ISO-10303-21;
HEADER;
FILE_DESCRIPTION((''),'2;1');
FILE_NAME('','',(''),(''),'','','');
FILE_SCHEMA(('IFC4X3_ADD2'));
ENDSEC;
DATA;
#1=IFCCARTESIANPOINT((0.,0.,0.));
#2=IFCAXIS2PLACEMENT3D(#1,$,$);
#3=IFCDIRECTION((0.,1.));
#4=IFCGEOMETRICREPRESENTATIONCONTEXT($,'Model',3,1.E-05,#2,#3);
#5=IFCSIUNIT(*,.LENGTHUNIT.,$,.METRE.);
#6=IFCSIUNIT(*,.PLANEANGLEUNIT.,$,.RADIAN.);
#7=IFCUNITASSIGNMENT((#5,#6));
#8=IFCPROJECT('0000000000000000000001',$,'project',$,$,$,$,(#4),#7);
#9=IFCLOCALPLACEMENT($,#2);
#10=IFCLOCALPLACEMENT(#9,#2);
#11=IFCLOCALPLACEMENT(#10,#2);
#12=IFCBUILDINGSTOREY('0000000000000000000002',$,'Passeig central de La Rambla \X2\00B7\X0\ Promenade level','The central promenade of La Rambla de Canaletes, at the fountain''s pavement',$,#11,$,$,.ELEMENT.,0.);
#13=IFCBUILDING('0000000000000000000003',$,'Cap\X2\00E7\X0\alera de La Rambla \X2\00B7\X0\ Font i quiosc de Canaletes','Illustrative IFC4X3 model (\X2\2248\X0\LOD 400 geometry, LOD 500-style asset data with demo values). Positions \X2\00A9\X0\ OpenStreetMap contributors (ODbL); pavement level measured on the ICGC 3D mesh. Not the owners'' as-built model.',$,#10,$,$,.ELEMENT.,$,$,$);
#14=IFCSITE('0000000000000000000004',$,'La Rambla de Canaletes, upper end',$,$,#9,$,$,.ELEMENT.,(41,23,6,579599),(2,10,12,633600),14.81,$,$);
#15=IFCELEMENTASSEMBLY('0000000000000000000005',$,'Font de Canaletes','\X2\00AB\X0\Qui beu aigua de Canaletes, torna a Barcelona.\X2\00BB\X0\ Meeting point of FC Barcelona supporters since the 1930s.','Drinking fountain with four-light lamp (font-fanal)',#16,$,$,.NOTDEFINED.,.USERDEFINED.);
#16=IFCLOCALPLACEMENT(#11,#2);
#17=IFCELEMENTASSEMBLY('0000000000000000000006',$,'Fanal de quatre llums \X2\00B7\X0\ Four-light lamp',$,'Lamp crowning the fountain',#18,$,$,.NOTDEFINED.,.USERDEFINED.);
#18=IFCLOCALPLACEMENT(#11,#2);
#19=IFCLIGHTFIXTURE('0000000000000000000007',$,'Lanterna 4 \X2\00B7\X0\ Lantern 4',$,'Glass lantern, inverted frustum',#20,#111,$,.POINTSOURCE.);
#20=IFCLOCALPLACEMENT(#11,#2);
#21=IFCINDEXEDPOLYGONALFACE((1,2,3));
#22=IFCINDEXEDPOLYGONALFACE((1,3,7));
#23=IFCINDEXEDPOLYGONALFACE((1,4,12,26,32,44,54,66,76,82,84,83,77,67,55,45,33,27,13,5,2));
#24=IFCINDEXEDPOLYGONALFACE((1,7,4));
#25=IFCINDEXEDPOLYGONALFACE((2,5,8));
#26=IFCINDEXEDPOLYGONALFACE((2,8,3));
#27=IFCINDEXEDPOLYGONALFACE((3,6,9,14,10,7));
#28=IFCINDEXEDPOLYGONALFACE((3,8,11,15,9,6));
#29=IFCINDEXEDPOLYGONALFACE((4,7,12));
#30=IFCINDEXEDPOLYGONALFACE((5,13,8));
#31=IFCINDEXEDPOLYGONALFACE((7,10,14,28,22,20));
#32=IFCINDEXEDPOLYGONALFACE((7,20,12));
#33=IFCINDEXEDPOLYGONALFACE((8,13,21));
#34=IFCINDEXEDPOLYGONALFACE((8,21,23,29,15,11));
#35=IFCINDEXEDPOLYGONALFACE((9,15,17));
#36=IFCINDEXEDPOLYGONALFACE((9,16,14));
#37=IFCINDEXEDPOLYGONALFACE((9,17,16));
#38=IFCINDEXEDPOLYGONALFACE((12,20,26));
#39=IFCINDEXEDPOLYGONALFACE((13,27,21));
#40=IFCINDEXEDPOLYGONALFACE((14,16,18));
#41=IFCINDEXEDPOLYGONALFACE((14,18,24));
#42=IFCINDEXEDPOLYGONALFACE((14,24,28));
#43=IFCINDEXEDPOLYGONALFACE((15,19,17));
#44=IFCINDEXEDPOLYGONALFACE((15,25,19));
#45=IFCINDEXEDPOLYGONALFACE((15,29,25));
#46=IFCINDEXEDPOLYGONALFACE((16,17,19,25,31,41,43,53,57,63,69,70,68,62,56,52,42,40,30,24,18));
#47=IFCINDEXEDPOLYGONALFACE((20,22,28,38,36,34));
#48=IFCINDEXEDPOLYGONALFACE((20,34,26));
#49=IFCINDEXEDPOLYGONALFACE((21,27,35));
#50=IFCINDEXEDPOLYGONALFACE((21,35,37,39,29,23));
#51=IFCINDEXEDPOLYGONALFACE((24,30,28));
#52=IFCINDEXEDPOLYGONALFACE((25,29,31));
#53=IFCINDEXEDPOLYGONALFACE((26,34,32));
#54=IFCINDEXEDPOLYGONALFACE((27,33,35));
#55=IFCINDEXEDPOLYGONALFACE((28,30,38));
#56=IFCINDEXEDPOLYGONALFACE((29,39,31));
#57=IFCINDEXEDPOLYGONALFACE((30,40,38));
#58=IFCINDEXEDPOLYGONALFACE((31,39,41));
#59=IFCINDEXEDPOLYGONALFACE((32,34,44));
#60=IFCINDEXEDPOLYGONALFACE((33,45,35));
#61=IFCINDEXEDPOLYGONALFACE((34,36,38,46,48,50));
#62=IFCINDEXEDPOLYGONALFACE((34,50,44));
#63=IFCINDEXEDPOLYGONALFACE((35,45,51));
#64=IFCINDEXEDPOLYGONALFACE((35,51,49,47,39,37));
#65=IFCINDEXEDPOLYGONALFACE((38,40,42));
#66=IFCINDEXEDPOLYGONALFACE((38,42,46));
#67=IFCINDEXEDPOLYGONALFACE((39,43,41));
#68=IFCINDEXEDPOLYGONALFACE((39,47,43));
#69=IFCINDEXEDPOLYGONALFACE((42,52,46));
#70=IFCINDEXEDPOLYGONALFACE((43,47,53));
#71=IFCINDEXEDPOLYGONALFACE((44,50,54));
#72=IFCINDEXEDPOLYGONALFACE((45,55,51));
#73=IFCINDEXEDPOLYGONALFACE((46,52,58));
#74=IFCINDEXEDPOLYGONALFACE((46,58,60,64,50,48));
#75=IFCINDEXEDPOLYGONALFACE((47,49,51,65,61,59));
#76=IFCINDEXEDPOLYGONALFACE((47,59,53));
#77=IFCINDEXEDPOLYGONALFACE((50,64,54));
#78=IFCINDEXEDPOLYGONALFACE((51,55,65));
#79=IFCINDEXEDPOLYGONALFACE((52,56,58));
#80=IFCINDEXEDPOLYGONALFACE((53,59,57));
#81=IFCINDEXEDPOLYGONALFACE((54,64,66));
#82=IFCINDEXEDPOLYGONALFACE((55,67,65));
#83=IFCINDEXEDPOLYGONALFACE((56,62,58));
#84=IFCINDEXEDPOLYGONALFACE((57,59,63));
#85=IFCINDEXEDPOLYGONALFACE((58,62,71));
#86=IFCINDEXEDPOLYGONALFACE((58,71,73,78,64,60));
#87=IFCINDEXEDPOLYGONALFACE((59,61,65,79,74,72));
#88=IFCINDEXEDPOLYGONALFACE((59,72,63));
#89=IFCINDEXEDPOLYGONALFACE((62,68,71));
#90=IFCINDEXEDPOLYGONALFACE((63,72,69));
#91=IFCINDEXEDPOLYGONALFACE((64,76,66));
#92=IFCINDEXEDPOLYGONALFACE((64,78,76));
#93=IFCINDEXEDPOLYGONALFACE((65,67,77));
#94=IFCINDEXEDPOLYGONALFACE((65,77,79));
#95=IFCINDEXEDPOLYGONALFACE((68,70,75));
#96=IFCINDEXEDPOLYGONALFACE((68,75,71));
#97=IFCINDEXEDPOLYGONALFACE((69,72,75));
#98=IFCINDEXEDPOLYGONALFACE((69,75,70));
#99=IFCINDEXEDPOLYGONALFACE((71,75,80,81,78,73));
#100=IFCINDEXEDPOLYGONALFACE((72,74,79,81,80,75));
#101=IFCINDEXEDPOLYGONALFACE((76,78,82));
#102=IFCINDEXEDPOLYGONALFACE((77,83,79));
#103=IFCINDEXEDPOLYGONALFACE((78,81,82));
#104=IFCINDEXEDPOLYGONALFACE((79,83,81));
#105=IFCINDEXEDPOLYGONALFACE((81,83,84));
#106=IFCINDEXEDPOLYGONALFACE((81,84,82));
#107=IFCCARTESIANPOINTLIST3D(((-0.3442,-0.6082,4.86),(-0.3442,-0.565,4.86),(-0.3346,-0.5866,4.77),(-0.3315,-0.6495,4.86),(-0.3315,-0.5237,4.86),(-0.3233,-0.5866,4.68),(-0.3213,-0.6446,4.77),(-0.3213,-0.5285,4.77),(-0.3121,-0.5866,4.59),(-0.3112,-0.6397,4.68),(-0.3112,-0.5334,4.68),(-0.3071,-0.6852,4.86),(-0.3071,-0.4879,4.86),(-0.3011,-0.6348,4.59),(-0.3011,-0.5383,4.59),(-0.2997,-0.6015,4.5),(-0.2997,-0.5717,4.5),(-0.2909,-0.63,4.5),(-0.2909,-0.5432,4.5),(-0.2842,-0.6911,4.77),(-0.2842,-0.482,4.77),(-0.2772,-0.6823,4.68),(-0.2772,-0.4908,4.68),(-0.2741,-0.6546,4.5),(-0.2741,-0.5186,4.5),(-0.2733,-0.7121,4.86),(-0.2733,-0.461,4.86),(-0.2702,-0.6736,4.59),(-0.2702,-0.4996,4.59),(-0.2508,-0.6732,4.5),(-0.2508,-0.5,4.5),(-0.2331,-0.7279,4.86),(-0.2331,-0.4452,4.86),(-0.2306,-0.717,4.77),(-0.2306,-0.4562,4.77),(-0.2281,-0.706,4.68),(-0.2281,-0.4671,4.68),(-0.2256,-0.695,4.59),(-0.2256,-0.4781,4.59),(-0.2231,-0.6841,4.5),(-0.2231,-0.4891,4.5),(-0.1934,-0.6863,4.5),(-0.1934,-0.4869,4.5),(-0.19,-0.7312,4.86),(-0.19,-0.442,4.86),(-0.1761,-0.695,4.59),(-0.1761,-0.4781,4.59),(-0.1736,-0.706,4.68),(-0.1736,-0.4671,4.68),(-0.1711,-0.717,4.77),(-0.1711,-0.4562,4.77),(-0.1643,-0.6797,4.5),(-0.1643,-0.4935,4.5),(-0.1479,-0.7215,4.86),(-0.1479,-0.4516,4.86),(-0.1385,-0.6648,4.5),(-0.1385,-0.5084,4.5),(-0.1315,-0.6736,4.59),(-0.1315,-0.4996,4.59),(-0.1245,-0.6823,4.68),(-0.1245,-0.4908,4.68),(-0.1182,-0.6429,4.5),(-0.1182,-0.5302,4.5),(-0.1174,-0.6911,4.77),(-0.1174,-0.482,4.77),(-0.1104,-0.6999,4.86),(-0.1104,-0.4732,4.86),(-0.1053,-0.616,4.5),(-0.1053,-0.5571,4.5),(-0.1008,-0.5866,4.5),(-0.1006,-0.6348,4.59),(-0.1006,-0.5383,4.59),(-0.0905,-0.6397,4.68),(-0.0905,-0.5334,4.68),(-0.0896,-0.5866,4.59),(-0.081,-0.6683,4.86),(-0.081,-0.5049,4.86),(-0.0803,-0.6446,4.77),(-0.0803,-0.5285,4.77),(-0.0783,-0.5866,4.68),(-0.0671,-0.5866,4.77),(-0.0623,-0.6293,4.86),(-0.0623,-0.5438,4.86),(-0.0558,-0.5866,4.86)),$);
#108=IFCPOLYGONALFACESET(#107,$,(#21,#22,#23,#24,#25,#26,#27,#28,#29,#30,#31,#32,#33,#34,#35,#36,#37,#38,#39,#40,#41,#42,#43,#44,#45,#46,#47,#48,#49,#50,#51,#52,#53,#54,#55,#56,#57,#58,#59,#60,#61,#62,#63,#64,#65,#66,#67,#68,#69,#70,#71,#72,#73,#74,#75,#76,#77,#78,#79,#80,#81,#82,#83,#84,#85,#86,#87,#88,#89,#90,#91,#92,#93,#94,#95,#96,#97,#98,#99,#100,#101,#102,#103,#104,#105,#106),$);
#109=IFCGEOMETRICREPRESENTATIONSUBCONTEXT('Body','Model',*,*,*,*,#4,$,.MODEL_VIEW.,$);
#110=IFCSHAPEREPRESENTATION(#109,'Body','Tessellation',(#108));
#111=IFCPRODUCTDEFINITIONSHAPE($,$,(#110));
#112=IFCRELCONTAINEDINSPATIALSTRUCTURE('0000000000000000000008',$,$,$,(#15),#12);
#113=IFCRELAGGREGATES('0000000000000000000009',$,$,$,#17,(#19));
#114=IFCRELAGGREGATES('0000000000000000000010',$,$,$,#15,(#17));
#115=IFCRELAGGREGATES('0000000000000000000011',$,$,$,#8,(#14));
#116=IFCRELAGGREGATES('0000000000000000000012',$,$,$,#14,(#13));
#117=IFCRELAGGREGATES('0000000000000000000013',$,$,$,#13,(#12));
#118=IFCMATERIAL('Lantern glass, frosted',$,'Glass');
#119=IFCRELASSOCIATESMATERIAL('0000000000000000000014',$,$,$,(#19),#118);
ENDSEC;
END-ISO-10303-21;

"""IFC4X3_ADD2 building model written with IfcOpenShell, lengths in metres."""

from ifc_helpers import new_model, entity, si_unit, direction, origin, place, context, subcontext, project, spatial, material, element, aggregate, save


model = new_model("IFC4X3_ADD2")

# Units and contexts
model_context = context("Model", 3, precision=1e-05, world=origin(), true_north=direction((0.0, 1.0)))
body_context = subcontext(model_context, "Body", "Model", "MODEL_VIEW")
ifc_project = project(units=[si_unit("LENGTHUNIT", "METRE"), si_unit("PLANEANGLEUNIT", "RADIAN")], contexts=[model_context])

# Site, building, storey
site_placement = place(None, origin())
site = spatial("IfcSite", under=ifc_project, at=site_placement, Name="La Rambla de Canaletes, upper end", CompositionType="ELEMENT", RefLatitude=(41, 23, 6, 579599), RefLongitude=(2, 10, 12, 633600), RefElevation=14.81)
building_placement = place(site_placement, origin())
building = spatial("IfcBuilding", under=site, at=building_placement, Name="Capçalera de La Rambla · Font i quiosc de Canaletes", Description="Illustrative IFC4X3 model (≈LOD 400 geometry, LOD 500-style asset data with demo values). Positions © OpenStreetMap contributors (ODbL); pavement level measured on the ICGC 3D mesh. Not the owners' as-built model.", CompositionType="ELEMENT")
storey_placement = place(building_placement, origin())
storey = spatial("IfcBuildingStorey", under=building, at=storey_placement, Name="Passeig central de La Rambla · Promenade level", Description="The central promenade of La Rambla de Canaletes, at the fountain's pavement", CompositionType="ELEMENT", Elevation=0.0)

# Element assemblies, light fixture
assembly_1_placement = place(building_placement, origin())
assembly_1 = element("IfcElementAssembly", 1, at=assembly_1_placement, inside=storey, Name="Font de Canaletes", Description="«Qui beu aigua de Canaletes, torna a Barcelona.» Meeting point of FC Barcelona supporters since the 1930s.", ObjectType="Drinking fountain with four-light lamp (font-fanal)", AssemblyPlace="NOTDEFINED", PredefinedType="USERDEFINED")
assembly_2_placement = place(building_placement, origin())
assembly_2 = element("IfcElementAssembly", 2, at=assembly_2_placement, Name="Fanal de quatre llums · Four-light lamp", ObjectType="Lamp crowning the fountain", AssemblyPlace="NOTDEFINED", PredefinedType="USERDEFINED")
ifc_material_1 = material(Name="Lantern glass, frosted", Category="Glass")
light_fixture_1_placement = place(building_placement, origin())
light_fixture_1 = element("IfcLightFixture", 3, at=light_fixture_1_placement, material=ifc_material_1, Name="Lanterna 4 · Lantern 4", ObjectType="Glass lantern, inverted frustum", PredefinedType="POINTSOURCE", context=body_context, shape_type="SweptSolid", body=[
    entity("IfcRevolvedAreaSolid", entity("IfcArbitraryClosedProfileDef", "AREA", None, entity("IfcPolyline", [entity("IfcCartesianPoint", [0.0, 0.0]), entity("IfcCartesianPoint", [0.1, 0.0]), entity("IfcCartesianPoint", [0.145, 0.36]), entity("IfcCartesianPoint", [0.0, 0.36]), entity("IfcCartesianPoint", [0.0, 0.0])])), entity("IfcAxis2Placement3D", entity("IfcCartesianPoint", [-0.2008, -0.5866, 4.5]), entity("IfcDirection", [0.0, -1.0, 0.0]), entity("IfcDirection", [1.0, 0.0, 0.0])), entity("IfcAxis1Placement", entity("IfcCartesianPoint", [0.0, 0.0, 0.0]), entity("IfcDirection", [0.0, 1.0, 0.0])), 6.283185),
])
aggregate(assembly_2, [light_fixture_1])
aggregate(assembly_1, [assembly_2])

save(model, "model.ifc")
